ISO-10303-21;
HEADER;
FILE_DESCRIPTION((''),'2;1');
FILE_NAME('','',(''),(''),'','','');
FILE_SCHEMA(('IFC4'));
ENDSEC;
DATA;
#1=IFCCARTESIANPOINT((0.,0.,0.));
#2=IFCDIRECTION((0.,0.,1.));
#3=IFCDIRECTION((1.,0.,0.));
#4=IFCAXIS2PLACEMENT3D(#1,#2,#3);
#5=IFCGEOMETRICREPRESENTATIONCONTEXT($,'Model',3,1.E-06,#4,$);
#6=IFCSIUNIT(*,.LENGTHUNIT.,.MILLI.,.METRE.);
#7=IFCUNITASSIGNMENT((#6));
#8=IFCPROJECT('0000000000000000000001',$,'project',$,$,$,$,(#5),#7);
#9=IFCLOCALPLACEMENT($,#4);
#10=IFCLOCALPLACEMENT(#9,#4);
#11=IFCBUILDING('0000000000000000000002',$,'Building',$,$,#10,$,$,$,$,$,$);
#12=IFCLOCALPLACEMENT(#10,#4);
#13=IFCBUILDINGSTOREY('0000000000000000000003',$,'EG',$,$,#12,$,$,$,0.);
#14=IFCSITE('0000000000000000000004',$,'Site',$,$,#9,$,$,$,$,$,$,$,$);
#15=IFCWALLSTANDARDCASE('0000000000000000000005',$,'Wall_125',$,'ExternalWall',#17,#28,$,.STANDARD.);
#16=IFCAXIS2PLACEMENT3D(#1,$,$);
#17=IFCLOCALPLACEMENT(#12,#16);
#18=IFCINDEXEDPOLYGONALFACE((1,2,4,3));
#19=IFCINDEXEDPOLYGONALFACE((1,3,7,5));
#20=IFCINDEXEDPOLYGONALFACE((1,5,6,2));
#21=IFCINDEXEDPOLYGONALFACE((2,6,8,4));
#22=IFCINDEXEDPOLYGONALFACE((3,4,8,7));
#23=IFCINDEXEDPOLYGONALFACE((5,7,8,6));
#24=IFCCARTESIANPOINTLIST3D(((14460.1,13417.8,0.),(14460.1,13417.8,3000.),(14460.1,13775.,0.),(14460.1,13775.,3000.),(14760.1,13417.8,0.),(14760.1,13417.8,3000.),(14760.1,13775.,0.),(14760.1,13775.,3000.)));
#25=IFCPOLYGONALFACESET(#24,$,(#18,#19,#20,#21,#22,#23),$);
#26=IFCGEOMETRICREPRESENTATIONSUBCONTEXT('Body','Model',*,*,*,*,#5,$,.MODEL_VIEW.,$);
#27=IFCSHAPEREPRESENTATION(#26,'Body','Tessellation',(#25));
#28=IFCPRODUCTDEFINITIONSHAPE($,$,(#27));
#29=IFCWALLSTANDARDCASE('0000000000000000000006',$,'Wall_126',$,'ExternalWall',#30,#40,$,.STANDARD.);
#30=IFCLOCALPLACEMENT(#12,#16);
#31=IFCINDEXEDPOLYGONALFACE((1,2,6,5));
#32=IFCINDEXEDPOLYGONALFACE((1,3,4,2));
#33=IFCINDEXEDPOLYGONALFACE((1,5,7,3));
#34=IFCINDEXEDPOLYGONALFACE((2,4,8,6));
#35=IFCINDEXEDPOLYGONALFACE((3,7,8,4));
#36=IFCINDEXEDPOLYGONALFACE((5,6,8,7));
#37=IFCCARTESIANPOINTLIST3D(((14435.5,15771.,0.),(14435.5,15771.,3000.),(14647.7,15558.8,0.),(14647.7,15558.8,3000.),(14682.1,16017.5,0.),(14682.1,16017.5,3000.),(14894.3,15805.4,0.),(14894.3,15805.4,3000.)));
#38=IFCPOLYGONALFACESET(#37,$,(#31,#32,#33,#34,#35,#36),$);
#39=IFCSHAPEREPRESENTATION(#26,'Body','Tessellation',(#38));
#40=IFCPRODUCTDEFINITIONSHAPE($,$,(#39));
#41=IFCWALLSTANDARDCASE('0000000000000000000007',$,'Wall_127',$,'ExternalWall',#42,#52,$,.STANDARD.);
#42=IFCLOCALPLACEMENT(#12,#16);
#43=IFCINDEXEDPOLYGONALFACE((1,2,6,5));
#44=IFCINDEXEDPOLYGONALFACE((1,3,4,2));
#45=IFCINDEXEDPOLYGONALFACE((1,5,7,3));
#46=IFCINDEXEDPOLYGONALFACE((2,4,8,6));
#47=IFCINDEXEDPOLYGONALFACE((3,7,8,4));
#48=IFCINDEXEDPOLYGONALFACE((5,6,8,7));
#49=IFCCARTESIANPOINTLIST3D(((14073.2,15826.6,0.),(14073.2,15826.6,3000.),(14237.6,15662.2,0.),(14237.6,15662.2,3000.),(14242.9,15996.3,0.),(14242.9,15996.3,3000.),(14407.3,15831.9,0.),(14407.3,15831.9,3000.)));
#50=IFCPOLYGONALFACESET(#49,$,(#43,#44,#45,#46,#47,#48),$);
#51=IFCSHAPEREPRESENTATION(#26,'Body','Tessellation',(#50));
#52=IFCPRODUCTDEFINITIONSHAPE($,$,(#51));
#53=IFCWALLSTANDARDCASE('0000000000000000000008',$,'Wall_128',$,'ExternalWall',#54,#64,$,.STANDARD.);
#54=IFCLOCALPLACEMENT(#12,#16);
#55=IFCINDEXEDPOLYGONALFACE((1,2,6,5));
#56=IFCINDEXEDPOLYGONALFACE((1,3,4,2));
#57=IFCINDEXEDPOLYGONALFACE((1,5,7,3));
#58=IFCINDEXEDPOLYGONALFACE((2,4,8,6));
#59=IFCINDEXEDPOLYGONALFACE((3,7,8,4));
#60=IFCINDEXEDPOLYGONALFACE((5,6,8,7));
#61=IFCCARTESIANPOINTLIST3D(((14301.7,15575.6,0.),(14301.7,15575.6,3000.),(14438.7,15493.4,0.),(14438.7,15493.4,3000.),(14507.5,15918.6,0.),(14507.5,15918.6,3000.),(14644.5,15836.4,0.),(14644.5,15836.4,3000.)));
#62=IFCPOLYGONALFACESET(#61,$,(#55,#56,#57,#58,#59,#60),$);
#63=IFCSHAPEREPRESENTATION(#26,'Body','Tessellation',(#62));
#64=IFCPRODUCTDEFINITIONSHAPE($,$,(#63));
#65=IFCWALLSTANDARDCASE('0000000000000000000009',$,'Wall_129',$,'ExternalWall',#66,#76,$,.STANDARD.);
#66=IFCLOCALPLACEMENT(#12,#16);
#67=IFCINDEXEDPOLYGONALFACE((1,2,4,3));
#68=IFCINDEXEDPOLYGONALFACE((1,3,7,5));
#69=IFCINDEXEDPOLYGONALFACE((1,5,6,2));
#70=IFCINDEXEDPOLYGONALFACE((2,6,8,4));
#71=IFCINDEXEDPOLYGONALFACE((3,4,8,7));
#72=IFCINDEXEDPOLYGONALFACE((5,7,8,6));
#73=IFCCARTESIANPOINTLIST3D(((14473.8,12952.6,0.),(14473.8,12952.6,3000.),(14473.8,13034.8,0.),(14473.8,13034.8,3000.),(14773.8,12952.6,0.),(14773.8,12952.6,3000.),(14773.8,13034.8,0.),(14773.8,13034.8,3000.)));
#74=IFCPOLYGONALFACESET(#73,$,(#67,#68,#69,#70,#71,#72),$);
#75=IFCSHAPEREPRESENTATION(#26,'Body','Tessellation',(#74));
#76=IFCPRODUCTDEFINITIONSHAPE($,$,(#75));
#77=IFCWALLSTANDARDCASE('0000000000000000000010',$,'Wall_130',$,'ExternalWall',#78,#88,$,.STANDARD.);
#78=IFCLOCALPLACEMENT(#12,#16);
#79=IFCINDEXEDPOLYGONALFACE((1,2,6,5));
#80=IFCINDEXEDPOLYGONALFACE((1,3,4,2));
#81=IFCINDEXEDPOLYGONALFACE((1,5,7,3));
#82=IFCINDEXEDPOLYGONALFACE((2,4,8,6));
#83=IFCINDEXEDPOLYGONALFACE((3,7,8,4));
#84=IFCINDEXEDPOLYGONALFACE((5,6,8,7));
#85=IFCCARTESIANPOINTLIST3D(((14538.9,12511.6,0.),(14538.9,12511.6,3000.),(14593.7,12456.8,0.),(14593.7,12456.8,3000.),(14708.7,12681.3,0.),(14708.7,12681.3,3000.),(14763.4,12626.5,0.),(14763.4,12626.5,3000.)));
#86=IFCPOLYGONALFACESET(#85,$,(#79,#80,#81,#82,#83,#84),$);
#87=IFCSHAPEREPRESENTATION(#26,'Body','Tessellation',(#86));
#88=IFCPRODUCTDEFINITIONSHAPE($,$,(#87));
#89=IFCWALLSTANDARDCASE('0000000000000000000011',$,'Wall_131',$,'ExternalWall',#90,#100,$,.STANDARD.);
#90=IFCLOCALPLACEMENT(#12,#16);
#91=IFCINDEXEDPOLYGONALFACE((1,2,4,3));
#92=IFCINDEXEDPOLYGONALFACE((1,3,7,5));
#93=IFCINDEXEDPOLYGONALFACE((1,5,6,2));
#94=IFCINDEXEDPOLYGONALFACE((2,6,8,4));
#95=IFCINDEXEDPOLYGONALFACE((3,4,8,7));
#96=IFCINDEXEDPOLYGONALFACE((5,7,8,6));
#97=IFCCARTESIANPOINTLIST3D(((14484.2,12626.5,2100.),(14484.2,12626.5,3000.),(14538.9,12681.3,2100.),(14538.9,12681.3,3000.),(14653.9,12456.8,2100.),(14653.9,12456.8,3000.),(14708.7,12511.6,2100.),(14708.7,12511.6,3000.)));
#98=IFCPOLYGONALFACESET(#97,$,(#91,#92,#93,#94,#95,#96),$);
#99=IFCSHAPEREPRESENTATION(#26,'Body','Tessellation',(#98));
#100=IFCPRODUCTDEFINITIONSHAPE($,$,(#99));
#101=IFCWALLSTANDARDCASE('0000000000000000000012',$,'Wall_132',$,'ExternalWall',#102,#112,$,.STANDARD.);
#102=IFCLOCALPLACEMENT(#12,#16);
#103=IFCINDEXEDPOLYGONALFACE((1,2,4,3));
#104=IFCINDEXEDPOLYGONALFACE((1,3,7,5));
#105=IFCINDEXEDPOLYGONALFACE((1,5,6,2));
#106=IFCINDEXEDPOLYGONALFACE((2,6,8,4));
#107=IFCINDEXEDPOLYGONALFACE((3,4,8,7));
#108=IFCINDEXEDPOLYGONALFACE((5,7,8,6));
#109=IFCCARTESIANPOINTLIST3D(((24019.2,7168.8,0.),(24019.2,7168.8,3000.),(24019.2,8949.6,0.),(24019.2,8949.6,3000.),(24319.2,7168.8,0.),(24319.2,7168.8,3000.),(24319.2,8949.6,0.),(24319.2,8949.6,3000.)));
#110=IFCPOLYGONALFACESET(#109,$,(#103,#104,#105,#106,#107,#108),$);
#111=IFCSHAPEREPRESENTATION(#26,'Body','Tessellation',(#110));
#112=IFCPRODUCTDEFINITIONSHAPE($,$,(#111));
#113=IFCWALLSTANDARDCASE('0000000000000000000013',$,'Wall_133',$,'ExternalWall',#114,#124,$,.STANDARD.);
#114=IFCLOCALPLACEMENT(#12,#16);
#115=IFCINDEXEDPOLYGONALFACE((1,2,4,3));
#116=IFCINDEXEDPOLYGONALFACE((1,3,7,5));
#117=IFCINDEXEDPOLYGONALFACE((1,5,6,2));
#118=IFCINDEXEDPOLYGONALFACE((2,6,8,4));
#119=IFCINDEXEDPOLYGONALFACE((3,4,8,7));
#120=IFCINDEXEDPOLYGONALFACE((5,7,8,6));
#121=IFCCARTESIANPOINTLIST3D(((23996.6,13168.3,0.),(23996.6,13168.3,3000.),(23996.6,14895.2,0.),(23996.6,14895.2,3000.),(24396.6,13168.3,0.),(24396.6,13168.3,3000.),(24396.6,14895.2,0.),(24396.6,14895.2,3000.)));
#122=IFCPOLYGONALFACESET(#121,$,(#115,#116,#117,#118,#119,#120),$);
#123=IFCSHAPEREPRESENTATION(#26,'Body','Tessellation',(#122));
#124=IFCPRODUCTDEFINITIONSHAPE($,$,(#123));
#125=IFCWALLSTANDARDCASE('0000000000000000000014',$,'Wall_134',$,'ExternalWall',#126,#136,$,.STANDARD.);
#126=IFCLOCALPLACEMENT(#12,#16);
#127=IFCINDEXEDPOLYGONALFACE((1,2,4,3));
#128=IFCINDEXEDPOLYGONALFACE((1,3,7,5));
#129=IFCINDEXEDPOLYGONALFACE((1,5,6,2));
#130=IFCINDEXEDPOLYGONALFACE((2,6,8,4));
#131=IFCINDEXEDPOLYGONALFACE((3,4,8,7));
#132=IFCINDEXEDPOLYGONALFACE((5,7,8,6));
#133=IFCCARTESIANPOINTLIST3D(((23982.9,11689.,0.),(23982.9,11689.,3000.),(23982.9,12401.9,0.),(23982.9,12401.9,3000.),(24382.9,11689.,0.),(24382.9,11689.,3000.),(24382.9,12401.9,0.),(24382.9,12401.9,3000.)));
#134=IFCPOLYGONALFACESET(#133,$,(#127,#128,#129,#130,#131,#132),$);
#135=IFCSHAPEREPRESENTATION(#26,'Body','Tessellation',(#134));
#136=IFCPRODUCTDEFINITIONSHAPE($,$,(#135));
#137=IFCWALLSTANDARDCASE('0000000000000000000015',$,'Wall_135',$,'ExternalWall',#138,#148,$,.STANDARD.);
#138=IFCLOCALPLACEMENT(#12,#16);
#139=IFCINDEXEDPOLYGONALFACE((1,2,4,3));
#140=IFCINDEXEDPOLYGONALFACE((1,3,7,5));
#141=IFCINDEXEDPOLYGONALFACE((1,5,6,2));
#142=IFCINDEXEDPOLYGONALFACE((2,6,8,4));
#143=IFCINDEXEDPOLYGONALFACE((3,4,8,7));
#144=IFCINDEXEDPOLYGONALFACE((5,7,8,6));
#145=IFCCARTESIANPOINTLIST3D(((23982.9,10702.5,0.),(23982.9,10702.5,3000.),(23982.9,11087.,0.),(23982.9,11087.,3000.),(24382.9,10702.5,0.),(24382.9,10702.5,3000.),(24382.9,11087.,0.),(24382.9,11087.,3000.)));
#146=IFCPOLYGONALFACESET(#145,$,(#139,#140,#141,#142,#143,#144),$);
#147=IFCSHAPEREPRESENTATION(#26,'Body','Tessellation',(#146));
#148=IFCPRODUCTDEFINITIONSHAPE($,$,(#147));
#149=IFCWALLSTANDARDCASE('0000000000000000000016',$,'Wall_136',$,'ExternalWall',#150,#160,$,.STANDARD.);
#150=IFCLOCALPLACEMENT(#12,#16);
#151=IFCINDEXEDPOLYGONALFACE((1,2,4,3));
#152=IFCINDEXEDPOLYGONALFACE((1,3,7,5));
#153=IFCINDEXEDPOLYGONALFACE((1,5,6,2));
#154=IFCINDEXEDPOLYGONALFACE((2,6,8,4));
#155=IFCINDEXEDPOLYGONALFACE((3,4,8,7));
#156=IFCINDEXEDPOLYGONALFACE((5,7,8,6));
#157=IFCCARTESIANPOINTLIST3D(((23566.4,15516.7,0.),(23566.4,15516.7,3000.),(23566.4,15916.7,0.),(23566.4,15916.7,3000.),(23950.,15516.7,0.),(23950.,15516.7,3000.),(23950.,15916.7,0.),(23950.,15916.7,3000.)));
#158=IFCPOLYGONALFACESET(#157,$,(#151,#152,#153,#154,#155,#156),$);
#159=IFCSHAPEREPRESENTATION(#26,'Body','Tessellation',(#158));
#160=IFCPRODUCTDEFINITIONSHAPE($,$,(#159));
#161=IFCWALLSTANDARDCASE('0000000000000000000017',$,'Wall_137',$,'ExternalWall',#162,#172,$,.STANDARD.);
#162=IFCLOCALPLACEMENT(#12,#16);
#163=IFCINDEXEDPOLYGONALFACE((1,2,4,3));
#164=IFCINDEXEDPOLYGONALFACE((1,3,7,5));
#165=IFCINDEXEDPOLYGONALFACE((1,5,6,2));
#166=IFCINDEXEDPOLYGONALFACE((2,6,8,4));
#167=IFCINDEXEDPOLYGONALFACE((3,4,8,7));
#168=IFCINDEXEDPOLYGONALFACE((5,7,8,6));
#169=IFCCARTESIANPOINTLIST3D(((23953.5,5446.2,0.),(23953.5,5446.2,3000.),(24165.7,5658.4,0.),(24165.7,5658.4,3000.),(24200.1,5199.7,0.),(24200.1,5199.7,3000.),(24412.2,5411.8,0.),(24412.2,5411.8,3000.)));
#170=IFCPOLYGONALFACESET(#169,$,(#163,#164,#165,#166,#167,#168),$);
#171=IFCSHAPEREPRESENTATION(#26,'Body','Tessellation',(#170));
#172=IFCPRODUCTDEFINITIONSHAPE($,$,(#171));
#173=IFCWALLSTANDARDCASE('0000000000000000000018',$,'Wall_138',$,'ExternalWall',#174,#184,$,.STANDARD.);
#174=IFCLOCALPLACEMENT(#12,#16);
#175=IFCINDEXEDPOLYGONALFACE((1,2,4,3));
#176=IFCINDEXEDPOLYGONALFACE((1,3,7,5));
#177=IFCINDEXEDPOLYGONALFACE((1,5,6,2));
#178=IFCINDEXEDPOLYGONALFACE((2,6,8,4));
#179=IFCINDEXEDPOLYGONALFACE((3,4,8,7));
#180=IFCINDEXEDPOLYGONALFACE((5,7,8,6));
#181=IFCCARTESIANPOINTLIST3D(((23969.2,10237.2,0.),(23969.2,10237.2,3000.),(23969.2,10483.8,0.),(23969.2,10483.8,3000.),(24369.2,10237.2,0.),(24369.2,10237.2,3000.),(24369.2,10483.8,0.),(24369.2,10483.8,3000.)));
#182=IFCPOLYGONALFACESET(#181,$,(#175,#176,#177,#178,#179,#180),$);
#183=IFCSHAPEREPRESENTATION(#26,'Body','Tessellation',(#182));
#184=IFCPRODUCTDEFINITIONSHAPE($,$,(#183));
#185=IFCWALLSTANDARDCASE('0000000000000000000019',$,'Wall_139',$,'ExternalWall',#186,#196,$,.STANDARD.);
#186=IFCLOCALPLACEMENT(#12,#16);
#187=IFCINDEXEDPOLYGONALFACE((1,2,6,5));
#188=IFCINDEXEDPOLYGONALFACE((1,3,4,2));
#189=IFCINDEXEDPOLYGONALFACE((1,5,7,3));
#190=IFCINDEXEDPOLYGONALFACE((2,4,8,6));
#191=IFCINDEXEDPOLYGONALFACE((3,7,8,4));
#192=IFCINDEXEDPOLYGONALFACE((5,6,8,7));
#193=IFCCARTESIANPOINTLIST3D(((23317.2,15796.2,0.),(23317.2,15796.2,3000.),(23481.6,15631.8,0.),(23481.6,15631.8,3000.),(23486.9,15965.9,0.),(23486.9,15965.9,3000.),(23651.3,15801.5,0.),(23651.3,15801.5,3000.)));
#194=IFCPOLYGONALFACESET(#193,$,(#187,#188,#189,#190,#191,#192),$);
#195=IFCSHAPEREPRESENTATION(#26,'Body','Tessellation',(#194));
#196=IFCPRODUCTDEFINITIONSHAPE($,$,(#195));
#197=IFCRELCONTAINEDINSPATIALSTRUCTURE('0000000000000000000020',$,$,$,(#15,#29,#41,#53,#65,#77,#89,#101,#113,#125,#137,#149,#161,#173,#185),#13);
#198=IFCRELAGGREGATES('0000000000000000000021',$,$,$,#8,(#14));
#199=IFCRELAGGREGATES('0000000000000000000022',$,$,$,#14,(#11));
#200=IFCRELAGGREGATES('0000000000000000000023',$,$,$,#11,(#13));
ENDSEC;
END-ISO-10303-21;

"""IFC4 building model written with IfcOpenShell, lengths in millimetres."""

from ifc_helpers import new_model, si_unit, frame, origin_with_axes, place, context, subcontext, project, spatial, rectangle, extrude, element, save


model = new_model("IFC4")

# Units and contexts
model_context = context("Model", 3, precision=1e-06, world=origin_with_axes())
body_context = subcontext(model_context, "Body", "Model", "MODEL_VIEW")
ifc_project = project(units=[si_unit("LENGTHUNIT", "METRE", prefix="MILLI")], contexts=[model_context])

# Site, building, storey
site_placement = place(None, origin_with_axes())
site = spatial("IfcSite", under=ifc_project, at=site_placement, Name="Site")
building_placement = place(site_placement, origin_with_axes())
building = spatial("IfcBuilding", under=site, at=building_placement, Name="Building")
storey_placement = place(building_placement, origin_with_axes())
storey = spatial("IfcBuildingStorey", under=building, at=storey_placement, Name="EG", Elevation=0.0)

# Walls
wall_1_placement = place(storey_placement, origin_with_axes())
element("IfcWallStandardCase", 1, at=wall_1_placement, inside=storey, Name="Wall_125", ObjectType="ExternalWall", PredefinedType="STANDARD", context=body_context, shape_type="SweptSolid", body=[
    extrude(rectangle(XDim=357.2, YDim=300.0), frame((14610.1, 13596.4, 0.0), z_axis=(0.0, 0.0, 1.0), x_axis=(0.0, -1.0, 0.0)), (0.0, 0.0, 1.0), 3000.0),
])
wall_2_placement = place(storey_placement, origin_with_axes())
element("IfcWallStandardCase", 2, at=wall_2_placement, inside=storey, Name="Wall_126", ObjectType="ExternalWall", PredefinedType="STANDARD", context=body_context, shape_type="SweptSolid", body=[
    extrude(rectangle(XDim=348.7, YDim=300.0), frame((14664.9, 15788.2, 0.0), z_axis=(0.0, 0.0, 1.0), x_axis=(0.707107, 0.707107, 0.0)), (0.0, 0.0, 1.0), 3000.0),
])
wall_3_placement = place(storey_placement, origin_with_axes())
element("IfcWallStandardCase", 3, at=wall_3_placement, inside=storey, Name="Wall_127", ObjectType="ExternalWall", PredefinedType="STANDARD", context=body_context, shape_type="SweptSolid", body=[
    extrude(rectangle(XDim=232.5, YDim=240.0), frame((14240.2, 15829.3, 0.0), z_axis=(0.0, 0.0, 1.0), x_axis=(-0.707107, 0.707107, 0.0)), (0.0, 0.0, 1.0), 3000.0),
])
wall_4_placement = place(storey_placement, origin_with_axes())
element("IfcWallStandardCase", 4, at=wall_4_placement, inside=storey, Name="Wall_128", ObjectType="ExternalWall", PredefinedType="STANDARD", context=body_context, shape_type="SweptSolid", body=[
    extrude(rectangle(XDim=159.8, YDim=400.0), frame((14473.1, 15706.0, 0.0), z_axis=(0.0, 0.0, 1.0), x_axis=(-0.857493, 0.514496, 0.0)), (0.0, 0.0, 1.0), 3000.0),
])
wall_5_placement = place(storey_placement, origin_with_axes())
element("IfcWallStandardCase", 5, at=wall_5_placement, inside=storey, Name="Wall_129", ObjectType="ExternalWall", PredefinedType="STANDARD", context=body_context, shape_type="SweptSolid", body=[
    extrude(rectangle(XDim=82.2, YDim=300.0), frame((14623.8, 12993.7, 0.0), z_axis=(0.0, 0.0, 1.0), x_axis=(0.0, -1.0, 0.0)), (0.0, 0.0, 1.0), 3000.0),
])
wall_6_placement = place(storey_placement, origin_with_axes())
element("IfcWallStandardCase", 6, at=wall_6_placement, inside=storey, Name="Wall_130", ObjectType="ExternalWall", PredefinedType="STANDARD", context=body_context, shape_type="SweptSolid", body=[
    extrude(rectangle(XDim=77.5, YDim=240.0), frame((14651.2, 12569.0, 0.0), z_axis=(0.0, 0.0, 1.0), x_axis=(0.707107, -0.707107, 0.0)), (0.0, 0.0, 1.0), 3000.0),
])

# Wall, opening
wall_7_placement = place(storey_placement, origin_with_axes())
wall_7 = element("IfcWallStandardCase", 7, at=wall_7_placement, inside=storey, Name="Wall_131", ObjectType="ExternalWall", PredefinedType="STANDARD", context=body_context, shape_type="SweptSolid", body=[
    extrude(rectangle(XDim=77.5, YDim=240.0), frame((14596.4, 12569.0, 0.0), z_axis=(0.0, 0.0, 1.0), x_axis=(-0.707107, -0.707107, 0.0)), (0.0, 0.0, 1.0), 3000.0),
])
opening_placement = place(wall_7_placement, origin_with_axes())
element("IfcOpeningElement", 8, at=opening_placement, inside=storey, cuts=wall_7, context=body_context, shape_type="SweptSolid", body=[
    extrude(rectangle(XDim=1089.4, YDim=240.0), frame((14246.5, 12219.1, 0.0), z_axis=(0.0, 0.0, 1.0), x_axis=(-0.707107, -0.707107, 0.0)), (0.0, 0.0, 1.0), 2100.0),
])

# Walls
wall_8_placement = place(storey_placement, origin_with_axes())
element("IfcWallStandardCase", 9, at=wall_8_placement, inside=storey, Name="Wall_132", ObjectType="ExternalWall", PredefinedType="STANDARD", context=body_context, shape_type="SweptSolid", body=[
    extrude(rectangle(XDim=1780.8, YDim=300.0), frame((24169.2, 8059.2, 0.0), z_axis=(0.0, 0.0, 1.0), x_axis=(0.0, -1.0, 0.0)), (0.0, 0.0, 1.0), 3000.0),
])
wall_9_placement = place(storey_placement, origin_with_axes())
element("IfcWallStandardCase", 10, at=wall_9_placement, inside=storey, Name="Wall_133", ObjectType="ExternalWall", PredefinedType="STANDARD", context=body_context, shape_type="SweptSolid", body=[
    extrude(rectangle(XDim=1726.9, YDim=400.0), frame((24196.6, 14031.8, 0.0), z_axis=(0.0, 0.0, 1.0), x_axis=(0.0, 1.0, 0.0)), (0.0, 0.0, 1.0), 3000.0),
])
wall_10_placement = place(storey_placement, origin_with_axes())
element("IfcWallStandardCase", 11, at=wall_10_placement, inside=storey, Name="Wall_134", ObjectType="ExternalWall", PredefinedType="STANDARD", context=body_context, shape_type="SweptSolid", body=[
    extrude(rectangle(XDim=712.9, YDim=400.0), frame((24182.9, 12045.5, 0.0), z_axis=(0.0, 0.0, 1.0), x_axis=(0.0, -1.0, 0.0)), (0.0, 0.0, 1.0), 3000.0),
])
wall_11_placement = place(storey_placement, origin_with_axes())
element("IfcWallStandardCase", 12, at=wall_11_placement, inside=storey, Name="Wall_135", ObjectType="ExternalWall", PredefinedType="STANDARD", context=body_context, shape_type="SweptSolid", body=[
    extrude(rectangle(XDim=384.5, YDim=400.0), frame((24182.9, 10894.8, 0.0), z_axis=(0.0, 0.0, 1.0), x_axis=(0.0, -1.0, 0.0)), (0.0, 0.0, 1.0), 3000.0),
])
wall_12_placement = place(storey_placement, origin_with_axes())
element("IfcWallStandardCase", 13, at=wall_12_placement, inside=storey, Name="Wall_136", ObjectType="ExternalWall", PredefinedType="STANDARD", context=body_context, shape_type="SweptSolid", body=[
    extrude(rectangle(XDim=383.6, YDim=400.0), frame((23758.2, 15716.7, 0.0), z_axis=(0.0, 0.0, 1.0), x_axis=(-1.0, 0.0, 0.0)), (0.0, 0.0, 1.0), 3000.0),
])
wall_13_placement = place(storey_placement, origin_with_axes())
element("IfcWallStandardCase", 14, at=wall_13_placement, inside=storey, Name="Wall_137", ObjectType="ExternalWall", PredefinedType="STANDARD", context=body_context, shape_type="SweptSolid", body=[
    extrude(rectangle(XDim=348.7, YDim=300.0), frame((24182.9, 5429.0, 0.0), z_axis=(0.0, 0.0, 1.0), x_axis=(0.707107, -0.707107, 0.0)), (0.0, 0.0, 1.0), 3000.0),
])
wall_14_placement = place(storey_placement, origin_with_axes())
element("IfcWallStandardCase", 15, at=wall_14_placement, inside=storey, Name="Wall_138", ObjectType="ExternalWall", PredefinedType="STANDARD", context=body_context, shape_type="SweptSolid", body=[
    extrude(rectangle(XDim=246.6, YDim=400.0), frame((24169.2, 10360.5, 0.0), z_axis=(0.0, 0.0, 1.0), x_axis=(0.0, -1.0, 0.0)), (0.0, 0.0, 1.0), 3000.0),
])
wall_15_placement = place(storey_placement, origin_with_axes())
element("IfcWallStandardCase", 16, at=wall_15_placement, inside=storey, Name="Wall_139", ObjectType="ExternalWall", PredefinedType="STANDARD", context=body_context, shape_type="SweptSolid", body=[
    extrude(rectangle(XDim=232.5, YDim=240.0), frame((23484.2, 15798.9, 0.0), z_axis=(0.0, 0.0, 1.0), x_axis=(-0.707107, 0.707107, 0.0)), (0.0, 0.0, 1.0), 3000.0),
])

save(model, "model.ifc")
